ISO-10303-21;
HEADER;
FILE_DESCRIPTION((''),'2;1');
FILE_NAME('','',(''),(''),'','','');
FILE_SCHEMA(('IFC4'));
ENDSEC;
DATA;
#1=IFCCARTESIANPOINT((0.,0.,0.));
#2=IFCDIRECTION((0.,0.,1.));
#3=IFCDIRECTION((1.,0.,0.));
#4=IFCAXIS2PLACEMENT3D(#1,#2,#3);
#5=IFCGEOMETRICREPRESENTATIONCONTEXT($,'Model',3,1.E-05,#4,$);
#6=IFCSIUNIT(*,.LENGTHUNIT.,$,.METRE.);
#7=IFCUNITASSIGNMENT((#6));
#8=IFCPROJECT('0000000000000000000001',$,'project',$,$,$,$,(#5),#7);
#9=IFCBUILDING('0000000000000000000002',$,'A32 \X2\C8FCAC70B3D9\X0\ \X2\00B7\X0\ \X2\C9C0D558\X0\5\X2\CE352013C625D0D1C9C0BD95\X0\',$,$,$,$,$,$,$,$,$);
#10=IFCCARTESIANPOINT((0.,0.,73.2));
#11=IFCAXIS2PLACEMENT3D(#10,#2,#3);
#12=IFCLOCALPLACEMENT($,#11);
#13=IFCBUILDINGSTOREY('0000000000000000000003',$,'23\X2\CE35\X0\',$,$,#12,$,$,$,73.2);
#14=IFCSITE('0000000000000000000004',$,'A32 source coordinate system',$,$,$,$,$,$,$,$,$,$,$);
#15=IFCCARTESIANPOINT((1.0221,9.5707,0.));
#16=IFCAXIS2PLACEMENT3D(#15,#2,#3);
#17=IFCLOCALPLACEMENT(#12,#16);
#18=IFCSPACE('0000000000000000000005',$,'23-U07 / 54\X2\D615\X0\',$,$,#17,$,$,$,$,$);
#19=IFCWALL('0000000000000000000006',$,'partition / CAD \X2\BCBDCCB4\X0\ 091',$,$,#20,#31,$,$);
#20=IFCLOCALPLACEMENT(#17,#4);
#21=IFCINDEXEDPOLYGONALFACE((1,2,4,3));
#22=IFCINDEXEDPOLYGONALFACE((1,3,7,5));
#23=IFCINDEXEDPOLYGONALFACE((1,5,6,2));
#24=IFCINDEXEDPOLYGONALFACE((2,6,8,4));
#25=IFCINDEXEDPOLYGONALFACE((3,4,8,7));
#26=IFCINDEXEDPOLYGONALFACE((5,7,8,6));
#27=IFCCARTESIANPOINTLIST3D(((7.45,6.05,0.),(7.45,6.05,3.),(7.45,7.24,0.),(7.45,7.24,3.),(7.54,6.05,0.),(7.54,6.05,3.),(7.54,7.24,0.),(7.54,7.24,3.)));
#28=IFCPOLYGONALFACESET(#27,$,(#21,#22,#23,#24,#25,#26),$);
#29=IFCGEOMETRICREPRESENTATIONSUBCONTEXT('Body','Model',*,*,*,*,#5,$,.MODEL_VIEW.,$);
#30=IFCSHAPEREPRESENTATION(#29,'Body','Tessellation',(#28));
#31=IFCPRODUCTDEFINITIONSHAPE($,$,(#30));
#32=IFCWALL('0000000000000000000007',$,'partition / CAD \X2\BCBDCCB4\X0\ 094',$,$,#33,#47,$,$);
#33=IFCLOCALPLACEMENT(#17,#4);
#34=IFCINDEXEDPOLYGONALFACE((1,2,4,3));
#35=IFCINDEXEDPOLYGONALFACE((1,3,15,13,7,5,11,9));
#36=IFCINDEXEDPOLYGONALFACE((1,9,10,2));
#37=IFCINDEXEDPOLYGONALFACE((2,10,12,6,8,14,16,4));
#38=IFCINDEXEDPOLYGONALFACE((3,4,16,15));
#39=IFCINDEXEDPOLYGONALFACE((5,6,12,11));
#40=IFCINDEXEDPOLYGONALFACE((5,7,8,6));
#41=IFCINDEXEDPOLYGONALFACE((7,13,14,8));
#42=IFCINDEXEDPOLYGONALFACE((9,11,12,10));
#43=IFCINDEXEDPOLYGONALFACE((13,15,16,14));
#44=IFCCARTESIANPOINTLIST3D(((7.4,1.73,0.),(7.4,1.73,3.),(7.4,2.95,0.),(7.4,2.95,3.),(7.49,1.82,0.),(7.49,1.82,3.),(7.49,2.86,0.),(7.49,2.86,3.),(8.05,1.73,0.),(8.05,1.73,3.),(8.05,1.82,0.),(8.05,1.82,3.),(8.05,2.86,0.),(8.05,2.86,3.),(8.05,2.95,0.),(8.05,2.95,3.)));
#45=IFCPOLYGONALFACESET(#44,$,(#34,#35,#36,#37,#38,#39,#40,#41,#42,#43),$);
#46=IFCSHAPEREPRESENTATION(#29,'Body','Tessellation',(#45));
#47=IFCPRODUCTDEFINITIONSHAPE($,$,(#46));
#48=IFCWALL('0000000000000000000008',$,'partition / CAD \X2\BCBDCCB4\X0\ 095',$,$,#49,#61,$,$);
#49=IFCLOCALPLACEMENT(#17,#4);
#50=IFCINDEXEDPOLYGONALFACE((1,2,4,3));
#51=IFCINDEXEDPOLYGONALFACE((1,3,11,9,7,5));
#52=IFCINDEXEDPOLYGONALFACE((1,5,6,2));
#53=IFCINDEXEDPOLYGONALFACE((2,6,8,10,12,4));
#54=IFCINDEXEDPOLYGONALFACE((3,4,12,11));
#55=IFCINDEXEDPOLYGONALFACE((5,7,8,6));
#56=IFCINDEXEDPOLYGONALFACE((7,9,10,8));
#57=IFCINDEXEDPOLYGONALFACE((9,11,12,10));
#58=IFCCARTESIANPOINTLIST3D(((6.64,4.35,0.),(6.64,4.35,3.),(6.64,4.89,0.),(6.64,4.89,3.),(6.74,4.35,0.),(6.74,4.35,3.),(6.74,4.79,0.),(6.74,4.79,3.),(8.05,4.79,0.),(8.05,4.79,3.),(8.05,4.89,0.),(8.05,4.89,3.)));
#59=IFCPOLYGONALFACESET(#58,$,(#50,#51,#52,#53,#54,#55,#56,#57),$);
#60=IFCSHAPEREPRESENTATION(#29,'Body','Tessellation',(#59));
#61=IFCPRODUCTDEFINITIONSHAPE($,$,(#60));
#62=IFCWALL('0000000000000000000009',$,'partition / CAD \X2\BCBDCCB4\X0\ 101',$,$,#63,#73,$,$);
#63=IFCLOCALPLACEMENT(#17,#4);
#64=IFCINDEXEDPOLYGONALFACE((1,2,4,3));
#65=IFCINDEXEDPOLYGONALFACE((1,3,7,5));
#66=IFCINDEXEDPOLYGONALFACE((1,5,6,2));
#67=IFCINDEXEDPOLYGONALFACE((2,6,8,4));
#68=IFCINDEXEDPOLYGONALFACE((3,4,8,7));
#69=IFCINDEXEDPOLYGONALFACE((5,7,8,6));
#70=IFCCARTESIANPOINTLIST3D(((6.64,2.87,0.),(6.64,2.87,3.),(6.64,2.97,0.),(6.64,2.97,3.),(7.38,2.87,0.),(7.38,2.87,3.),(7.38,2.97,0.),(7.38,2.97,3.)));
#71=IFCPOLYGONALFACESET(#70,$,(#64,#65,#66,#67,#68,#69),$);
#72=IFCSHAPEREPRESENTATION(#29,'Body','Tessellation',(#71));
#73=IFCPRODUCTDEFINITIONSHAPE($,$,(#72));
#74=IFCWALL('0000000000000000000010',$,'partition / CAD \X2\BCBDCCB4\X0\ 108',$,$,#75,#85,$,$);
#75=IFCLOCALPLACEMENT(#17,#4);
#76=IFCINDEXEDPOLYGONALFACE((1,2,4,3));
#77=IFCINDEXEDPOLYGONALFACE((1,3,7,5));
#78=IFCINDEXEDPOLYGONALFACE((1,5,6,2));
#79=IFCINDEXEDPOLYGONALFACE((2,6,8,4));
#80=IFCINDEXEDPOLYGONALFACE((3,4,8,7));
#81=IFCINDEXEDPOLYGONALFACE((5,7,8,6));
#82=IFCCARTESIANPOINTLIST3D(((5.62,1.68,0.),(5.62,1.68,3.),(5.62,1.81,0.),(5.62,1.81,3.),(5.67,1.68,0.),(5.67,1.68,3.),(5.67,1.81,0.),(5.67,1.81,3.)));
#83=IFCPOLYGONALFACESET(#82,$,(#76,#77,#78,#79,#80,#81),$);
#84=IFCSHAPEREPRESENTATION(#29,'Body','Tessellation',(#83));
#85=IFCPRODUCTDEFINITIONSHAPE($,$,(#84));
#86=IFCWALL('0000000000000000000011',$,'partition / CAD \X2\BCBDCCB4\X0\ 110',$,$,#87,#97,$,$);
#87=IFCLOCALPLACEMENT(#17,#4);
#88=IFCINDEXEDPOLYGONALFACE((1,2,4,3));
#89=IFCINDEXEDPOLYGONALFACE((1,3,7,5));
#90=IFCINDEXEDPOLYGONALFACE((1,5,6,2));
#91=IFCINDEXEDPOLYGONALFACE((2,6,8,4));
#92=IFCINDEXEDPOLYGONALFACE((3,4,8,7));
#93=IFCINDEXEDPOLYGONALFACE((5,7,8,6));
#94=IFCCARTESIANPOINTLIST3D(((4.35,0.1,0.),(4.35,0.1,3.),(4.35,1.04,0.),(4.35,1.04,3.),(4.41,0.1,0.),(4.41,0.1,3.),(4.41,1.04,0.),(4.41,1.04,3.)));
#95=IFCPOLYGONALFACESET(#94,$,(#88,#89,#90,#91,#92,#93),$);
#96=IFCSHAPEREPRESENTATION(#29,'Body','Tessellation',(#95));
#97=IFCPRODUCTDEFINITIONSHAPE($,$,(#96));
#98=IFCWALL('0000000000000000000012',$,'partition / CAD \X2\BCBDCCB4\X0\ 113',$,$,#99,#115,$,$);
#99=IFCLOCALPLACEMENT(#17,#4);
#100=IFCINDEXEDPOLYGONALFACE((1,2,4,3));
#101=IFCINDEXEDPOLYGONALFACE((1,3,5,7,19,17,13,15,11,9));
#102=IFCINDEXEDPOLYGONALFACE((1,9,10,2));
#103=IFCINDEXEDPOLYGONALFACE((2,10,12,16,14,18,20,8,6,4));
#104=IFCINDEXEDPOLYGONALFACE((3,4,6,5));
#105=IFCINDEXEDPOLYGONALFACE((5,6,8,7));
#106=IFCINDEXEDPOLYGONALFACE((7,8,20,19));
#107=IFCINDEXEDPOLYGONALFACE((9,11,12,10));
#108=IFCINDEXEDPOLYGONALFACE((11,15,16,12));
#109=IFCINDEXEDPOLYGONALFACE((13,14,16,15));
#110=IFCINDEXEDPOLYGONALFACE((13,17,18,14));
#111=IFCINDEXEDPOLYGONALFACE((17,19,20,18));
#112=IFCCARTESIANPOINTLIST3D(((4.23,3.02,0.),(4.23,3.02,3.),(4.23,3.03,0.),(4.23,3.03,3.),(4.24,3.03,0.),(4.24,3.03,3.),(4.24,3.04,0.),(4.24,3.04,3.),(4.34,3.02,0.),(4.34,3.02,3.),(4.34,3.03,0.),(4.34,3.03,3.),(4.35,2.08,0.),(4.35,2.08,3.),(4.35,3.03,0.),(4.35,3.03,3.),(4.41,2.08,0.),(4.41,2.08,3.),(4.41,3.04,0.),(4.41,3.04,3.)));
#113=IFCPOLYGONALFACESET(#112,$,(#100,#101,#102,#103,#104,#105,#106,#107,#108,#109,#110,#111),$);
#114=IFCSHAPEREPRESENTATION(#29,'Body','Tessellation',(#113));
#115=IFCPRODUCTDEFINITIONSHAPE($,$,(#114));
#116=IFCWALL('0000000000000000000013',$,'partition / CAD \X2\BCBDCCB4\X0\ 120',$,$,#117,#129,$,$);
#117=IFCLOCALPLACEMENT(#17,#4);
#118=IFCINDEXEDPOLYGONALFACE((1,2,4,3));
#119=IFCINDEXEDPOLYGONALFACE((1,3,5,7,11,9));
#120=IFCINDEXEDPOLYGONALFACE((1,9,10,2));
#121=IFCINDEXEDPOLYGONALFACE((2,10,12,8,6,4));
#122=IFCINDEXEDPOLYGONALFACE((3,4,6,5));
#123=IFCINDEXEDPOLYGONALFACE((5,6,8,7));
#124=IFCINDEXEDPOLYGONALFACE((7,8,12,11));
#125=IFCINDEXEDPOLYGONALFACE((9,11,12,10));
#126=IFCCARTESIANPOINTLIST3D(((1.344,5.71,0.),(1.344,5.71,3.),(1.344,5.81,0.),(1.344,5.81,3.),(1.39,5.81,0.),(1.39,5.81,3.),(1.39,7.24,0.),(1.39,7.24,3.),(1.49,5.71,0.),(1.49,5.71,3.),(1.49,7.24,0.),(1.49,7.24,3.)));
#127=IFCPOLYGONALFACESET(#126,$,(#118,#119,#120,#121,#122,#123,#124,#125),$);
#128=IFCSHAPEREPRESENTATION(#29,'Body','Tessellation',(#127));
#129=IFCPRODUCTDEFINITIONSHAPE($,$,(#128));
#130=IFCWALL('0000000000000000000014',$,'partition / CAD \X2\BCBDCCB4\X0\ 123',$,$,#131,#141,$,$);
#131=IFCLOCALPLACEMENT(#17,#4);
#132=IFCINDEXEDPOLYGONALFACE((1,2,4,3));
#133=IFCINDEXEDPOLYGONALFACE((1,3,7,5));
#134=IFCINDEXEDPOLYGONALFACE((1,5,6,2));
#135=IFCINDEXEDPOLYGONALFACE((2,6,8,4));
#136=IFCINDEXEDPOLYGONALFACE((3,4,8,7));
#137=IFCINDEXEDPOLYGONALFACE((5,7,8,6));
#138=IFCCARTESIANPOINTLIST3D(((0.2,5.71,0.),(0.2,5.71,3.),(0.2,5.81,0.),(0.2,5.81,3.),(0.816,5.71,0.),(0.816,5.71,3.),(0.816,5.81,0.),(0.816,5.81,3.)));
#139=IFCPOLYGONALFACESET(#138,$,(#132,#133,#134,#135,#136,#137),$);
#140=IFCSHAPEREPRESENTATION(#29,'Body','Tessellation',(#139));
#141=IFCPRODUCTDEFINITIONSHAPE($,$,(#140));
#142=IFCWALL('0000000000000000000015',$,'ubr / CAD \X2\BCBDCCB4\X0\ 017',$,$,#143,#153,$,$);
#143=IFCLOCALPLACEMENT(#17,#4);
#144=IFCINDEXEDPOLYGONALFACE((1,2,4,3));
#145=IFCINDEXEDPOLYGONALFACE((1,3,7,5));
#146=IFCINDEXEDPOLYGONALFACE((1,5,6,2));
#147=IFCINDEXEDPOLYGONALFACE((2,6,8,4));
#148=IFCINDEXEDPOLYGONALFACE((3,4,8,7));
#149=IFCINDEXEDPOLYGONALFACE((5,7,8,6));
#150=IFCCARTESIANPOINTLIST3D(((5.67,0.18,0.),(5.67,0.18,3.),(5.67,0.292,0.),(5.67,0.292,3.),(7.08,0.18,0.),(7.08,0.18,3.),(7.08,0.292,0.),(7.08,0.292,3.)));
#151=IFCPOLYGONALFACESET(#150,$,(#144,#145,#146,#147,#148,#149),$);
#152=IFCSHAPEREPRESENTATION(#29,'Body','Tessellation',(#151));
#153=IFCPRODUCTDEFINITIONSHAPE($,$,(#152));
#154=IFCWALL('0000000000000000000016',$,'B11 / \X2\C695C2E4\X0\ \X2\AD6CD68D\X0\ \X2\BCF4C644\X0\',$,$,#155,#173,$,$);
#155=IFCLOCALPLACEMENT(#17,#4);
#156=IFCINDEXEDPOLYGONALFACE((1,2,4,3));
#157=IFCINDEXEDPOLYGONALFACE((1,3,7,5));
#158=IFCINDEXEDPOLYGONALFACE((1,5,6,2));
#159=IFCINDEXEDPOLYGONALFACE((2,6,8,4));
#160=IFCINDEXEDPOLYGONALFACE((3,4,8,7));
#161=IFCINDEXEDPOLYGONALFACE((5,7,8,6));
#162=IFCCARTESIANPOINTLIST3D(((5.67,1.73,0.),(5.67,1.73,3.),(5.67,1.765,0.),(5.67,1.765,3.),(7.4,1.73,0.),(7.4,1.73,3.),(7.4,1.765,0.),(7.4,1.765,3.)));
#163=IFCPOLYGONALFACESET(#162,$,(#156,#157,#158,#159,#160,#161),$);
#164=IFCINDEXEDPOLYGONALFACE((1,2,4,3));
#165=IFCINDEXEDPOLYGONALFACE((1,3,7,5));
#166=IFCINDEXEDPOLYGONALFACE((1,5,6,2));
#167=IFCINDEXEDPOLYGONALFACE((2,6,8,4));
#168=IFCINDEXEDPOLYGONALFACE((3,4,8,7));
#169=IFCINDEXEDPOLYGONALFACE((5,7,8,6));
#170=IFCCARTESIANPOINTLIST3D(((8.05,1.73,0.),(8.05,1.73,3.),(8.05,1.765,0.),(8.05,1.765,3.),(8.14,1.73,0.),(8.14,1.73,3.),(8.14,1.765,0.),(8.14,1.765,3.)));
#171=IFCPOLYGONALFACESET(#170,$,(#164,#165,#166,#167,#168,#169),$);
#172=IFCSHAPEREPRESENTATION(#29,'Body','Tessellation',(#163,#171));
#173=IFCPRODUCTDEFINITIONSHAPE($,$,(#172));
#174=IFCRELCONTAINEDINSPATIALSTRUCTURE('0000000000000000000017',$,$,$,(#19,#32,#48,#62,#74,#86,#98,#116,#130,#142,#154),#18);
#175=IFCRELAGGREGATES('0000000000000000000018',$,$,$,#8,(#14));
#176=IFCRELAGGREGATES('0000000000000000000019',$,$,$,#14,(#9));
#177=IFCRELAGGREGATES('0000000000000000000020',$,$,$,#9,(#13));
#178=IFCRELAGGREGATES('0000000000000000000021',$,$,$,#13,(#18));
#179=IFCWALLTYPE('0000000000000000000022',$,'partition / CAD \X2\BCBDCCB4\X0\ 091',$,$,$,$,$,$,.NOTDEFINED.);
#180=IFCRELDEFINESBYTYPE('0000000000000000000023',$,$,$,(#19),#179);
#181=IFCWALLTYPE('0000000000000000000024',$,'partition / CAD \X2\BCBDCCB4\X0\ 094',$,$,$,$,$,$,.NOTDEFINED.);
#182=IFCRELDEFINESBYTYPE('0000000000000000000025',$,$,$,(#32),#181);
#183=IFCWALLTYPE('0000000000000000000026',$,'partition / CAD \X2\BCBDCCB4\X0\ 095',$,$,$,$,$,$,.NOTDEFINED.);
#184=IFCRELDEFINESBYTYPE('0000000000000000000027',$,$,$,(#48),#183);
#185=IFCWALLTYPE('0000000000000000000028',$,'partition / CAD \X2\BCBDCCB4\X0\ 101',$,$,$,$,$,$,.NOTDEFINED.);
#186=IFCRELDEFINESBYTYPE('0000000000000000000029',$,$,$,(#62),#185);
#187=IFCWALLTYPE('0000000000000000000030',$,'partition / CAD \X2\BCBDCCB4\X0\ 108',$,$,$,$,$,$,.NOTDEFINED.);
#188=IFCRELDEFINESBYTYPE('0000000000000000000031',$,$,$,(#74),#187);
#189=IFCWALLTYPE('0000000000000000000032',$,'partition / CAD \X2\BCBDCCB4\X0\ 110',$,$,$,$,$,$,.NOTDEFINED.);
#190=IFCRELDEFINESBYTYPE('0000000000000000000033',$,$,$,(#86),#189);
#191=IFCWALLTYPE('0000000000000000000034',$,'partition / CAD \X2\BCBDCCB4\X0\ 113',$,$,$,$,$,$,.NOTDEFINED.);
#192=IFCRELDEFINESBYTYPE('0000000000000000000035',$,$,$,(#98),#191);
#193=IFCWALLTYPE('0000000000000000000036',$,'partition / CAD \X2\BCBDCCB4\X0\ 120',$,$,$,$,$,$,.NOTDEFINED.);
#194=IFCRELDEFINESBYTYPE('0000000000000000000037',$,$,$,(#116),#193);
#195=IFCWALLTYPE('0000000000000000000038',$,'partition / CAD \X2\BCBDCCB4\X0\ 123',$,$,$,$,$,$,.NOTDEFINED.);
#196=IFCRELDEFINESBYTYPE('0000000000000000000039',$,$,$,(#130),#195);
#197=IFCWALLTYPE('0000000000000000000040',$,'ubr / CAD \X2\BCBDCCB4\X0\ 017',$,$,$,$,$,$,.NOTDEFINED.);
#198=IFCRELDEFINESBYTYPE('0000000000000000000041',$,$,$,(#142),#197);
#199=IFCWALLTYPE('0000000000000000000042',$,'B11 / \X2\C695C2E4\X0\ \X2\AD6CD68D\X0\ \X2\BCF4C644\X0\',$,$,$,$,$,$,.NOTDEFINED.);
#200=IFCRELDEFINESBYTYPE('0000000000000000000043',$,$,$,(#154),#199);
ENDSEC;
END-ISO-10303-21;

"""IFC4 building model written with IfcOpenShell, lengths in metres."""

from ifc_helpers import new_model, si_unit, frame, origin, origin_with_axes, place, context, subcontext, project, spatial, polyline, outline, extrude, source, transform, mapped, type_object, type_shapes, element, save


model = new_model("IFC4")

# Units and contexts
model_context = context("Model", 3, precision=1e-05, world=origin_with_axes())
body_context = subcontext(model_context, "Body", "Model", "MODEL_VIEW")
ifc_project = project(units=[si_unit("LENGTHUNIT", "METRE")], contexts=[model_context])

# Site, building, storey, space
site = spatial("IfcSite", under=ifc_project, Name="A32 source coordinate system")
building = spatial("IfcBuilding", under=site, Name="A32 주거동 · 지하5층–옥탑지붕")
storey_placement = place(None, frame((0.0, 0.0, 73.2), z_axis=(0.0, 0.0, 1.0), x_axis=(1.0, 0.0, 0.0)))
storey = spatial("IfcBuildingStorey", under=building, at=storey_placement, Name="23층", Elevation=73.2)
space_1_placement = place(storey_placement, frame((1.0221, 9.5707, 0.0), z_axis=(0.0, 0.0, 1.0), x_axis=(1.0, 0.0, 0.0)))
space_1 = spatial("IfcSpace", under=storey, at=space_1_placement, Name="23-U07 / 54형")

# Walls
wall_type_1 = type_object("IfcWallType", Name="partition / CAD 벽체 091", PredefinedType="NOTDEFINED")
shared_shape_1 = source(origin(), body_context, "Body", "SweptSolid", [
    extrude(outline(polyline([(7.54, 6.05), (7.45, 6.05), (7.45, 7.24), (7.54, 7.24), (7.54, 6.05)])), origin(), (0.0, 0.0, 1.0), 3.0),
])
type_shapes(wall_type_1, [shared_shape_1])
wall_1_placement = place(space_1_placement, origin_with_axes())
element("IfcWall", 1, at=wall_1_placement, inside=space_1, type_object=wall_type_1, Name="partition / CAD 벽체 091", context=body_context, shape_type="MappedRepresentation", body=[
    mapped(shared_shape_1, transform((0.0, 0.0, 0.0), scale=1.0)),
])
wall_type_2 = type_object("IfcWallType", Name="partition / CAD 벽체 094", PredefinedType="NOTDEFINED")
shared_shape_2 = source(origin(), body_context, "Body", "SweptSolid", [
    extrude(outline(polyline([(8.05, 1.73), (7.4, 1.73), (7.4, 2.95), (8.05, 2.95), (8.05, 2.86), (7.49, 2.86), (7.49, 1.82), (8.05, 1.82), (8.05, 1.73)])), origin(), (0.0, 0.0, 1.0), 3.0),
])
type_shapes(wall_type_2, [shared_shape_2])
wall_2_placement = place(space_1_placement, origin_with_axes())
element("IfcWall", 2, at=wall_2_placement, inside=space_1, type_object=wall_type_2, Name="partition / CAD 벽체 094", context=body_context, shape_type="MappedRepresentation", body=[
    mapped(shared_shape_2, transform((0.0, 0.0, 0.0), scale=1.0)),
])
wall_type_3 = type_object("IfcWallType", Name="partition / CAD 벽체 095", PredefinedType="NOTDEFINED")
shared_shape_3 = source(origin(), body_context, "Body", "SweptSolid", [
    extrude(outline(polyline([(6.64, 4.89), (8.05, 4.89), (8.05, 4.79), (6.74, 4.79), (6.74, 4.35), (6.64, 4.35), (6.64, 4.89)])), origin(), (0.0, 0.0, 1.0), 3.0),
])
type_shapes(wall_type_3, [shared_shape_3])
wall_3_placement = place(space_1_placement, origin_with_axes())
element("IfcWall", 3, at=wall_3_placement, inside=space_1, type_object=wall_type_3, Name="partition / CAD 벽체 095", context=body_context, shape_type="MappedRepresentation", body=[
    mapped(shared_shape_3, transform((0.0, 0.0, 0.0), scale=1.0)),
])
wall_type_4 = type_object("IfcWallType", Name="partition / CAD 벽체 101", PredefinedType="NOTDEFINED")
shared_shape_4 = source(origin(), body_context, "Body", "SweptSolid", [
    extrude(outline(polyline([(7.38, 2.97), (7.38, 2.87), (6.64, 2.87), (6.64, 2.97), (7.38, 2.97)])), origin(), (0.0, 0.0, 1.0), 3.0),
])
type_shapes(wall_type_4, [shared_shape_4])
wall_4_placement = place(space_1_placement, origin_with_axes())
element("IfcWall", 4, at=wall_4_placement, inside=space_1, type_object=wall_type_4, Name="partition / CAD 벽체 101", context=body_context, shape_type="MappedRepresentation", body=[
    mapped(shared_shape_4, transform((0.0, 0.0, 0.0), scale=1.0)),
])
wall_type_5 = type_object("IfcWallType", Name="partition / CAD 벽체 108", PredefinedType="NOTDEFINED")
shared_shape_5 = source(origin(), body_context, "Body", "SweptSolid", [
    extrude(outline(polyline([(5.67, 1.68), (5.62, 1.68), (5.62, 1.81), (5.67, 1.81), (5.67, 1.68)])), origin(), (0.0, 0.0, 1.0), 3.0),
])
type_shapes(wall_type_5, [shared_shape_5])
wall_5_placement = place(space_1_placement, origin_with_axes())
element("IfcWall", 5, at=wall_5_placement, inside=space_1, type_object=wall_type_5, Name="partition / CAD 벽체 108", context=body_context, shape_type="MappedRepresentation", body=[
    mapped(shared_shape_5, transform((0.0, 0.0, 0.0), scale=1.0)),
])
wall_type_6 = type_object("IfcWallType", Name="partition / CAD 벽체 110", PredefinedType="NOTDEFINED")
shared_shape_6 = source(origin(), body_context, "Body", "SweptSolid", [
    extrude(outline(polyline([(4.35, 1.04), (4.41, 1.04), (4.41, 0.1), (4.35, 0.1), (4.35, 1.04)])), origin(), (0.0, 0.0, 1.0), 3.0),
])
type_shapes(wall_type_6, [shared_shape_6])
wall_6_placement = place(space_1_placement, origin_with_axes())
element("IfcWall", 6, at=wall_6_placement, inside=space_1, type_object=wall_type_6, Name="partition / CAD 벽체 110", context=body_context, shape_type="MappedRepresentation", body=[
    mapped(shared_shape_6, transform((0.0, 0.0, 0.0), scale=1.0)),
])
wall_type_7 = type_object("IfcWallType", Name="partition / CAD 벽체 113", PredefinedType="NOTDEFINED")
shared_shape_7 = source(origin(), body_context, "Body", "SweptSolid", [
    extrude(outline(polyline([(4.24, 3.04), (4.41, 3.04), (4.41, 2.08), (4.35, 2.08), (4.35, 3.03), (4.34, 3.03), (4.34, 3.02), (4.23, 3.02), (4.23, 3.03), (4.24, 3.03), (4.24, 3.04)])), origin(), (0.0, 0.0, 1.0), 3.0),
])
type_shapes(wall_type_7, [shared_shape_7])
wall_7_placement = place(space_1_placement, origin_with_axes())
element("IfcWall", 7, at=wall_7_placement, inside=space_1, type_object=wall_type_7, Name="partition / CAD 벽체 113", context=body_context, shape_type="MappedRepresentation", body=[
    mapped(shared_shape_7, transform((0.0, 0.0, 0.0), scale=1.0)),
])
wall_type_8 = type_object("IfcWallType", Name="partition / CAD 벽체 120", PredefinedType="NOTDEFINED")
shared_shape_8 = source(origin(), body_context, "Body", "SweptSolid", [
    extrude(outline(polyline([(1.39, 7.24), (1.49, 7.24), (1.49, 5.71), (1.344, 5.71), (1.344, 5.81), (1.39, 5.81), (1.39, 7.24)])), origin(), (0.0, 0.0, 1.0), 3.0),
])
type_shapes(wall_type_8, [shared_shape_8])
wall_8_placement = place(space_1_placement, origin_with_axes())
element("IfcWall", 8, at=wall_8_placement, inside=space_1, type_object=wall_type_8, Name="partition / CAD 벽체 120", context=body_context, shape_type="MappedRepresentation", body=[
    mapped(shared_shape_8, transform((0.0, 0.0, 0.0), scale=1.0)),
])
wall_type_9 = type_object("IfcWallType", Name="partition / CAD 벽체 123", PredefinedType="NOTDEFINED")
shared_shape_9 = source(origin(), body_context, "Body", "SweptSolid", [
    extrude(outline(polyline([(0.816, 5.81), (0.816, 5.71), (0.2, 5.71), (0.2, 5.81), (0.816, 5.81)])), origin(), (0.0, 0.0, 1.0), 3.0),
])
type_shapes(wall_type_9, [shared_shape_9])
wall_9_placement = place(space_1_placement, origin_with_axes())
element("IfcWall", 9, at=wall_9_placement, inside=space_1, type_object=wall_type_9, Name="partition / CAD 벽체 123", context=body_context, shape_type="MappedRepresentation", body=[
    mapped(shared_shape_9, transform((0.0, 0.0, 0.0), scale=1.0)),
])
wall_type_10 = type_object("IfcWallType", Name="ubr / CAD 벽체 017", PredefinedType="NOTDEFINED")
shared_shape_10 = source(origin(), body_context, "Body", "SweptSolid", [
    extrude(outline(polyline([(7.08, 0.292), (7.08, 0.18), (5.67, 0.18), (5.67, 0.292), (7.08, 0.292)])), origin(), (0.0, 0.0, 1.0), 3.0),
])
type_shapes(wall_type_10, [shared_shape_10])
wall_10_placement = place(space_1_placement, origin_with_axes())
element("IfcWall", 10, at=wall_10_placement, inside=space_1, type_object=wall_type_10, Name="ubr / CAD 벽체 017", context=body_context, shape_type="MappedRepresentation", body=[
    mapped(shared_shape_10, transform((0.0, 0.0, 0.0), scale=1.0)),
])
wall_type_11 = type_object("IfcWallType", Name="B11 / 욕실 구획 보완", PredefinedType="NOTDEFINED")
shared_shape_11 = source(origin(), body_context, "Body", "SweptSolid", [
    extrude(outline(polyline([(7.4, 1.765), (7.4, 1.73), (5.67, 1.73), (5.67, 1.765), (7.4, 1.765)])), origin(), (0.0, 0.0, 1.0), 3.0),
    extrude(outline(polyline([(8.05, 1.73), (8.05, 1.765), (8.14, 1.765), (8.14, 1.73), (8.05, 1.73)])), origin(), (0.0, 0.0, 1.0), 3.0),
])
type_shapes(wall_type_11, [shared_shape_11])
wall_11_placement = place(space_1_placement, origin_with_axes())
element("IfcWall", 11, at=wall_11_placement, inside=space_1, type_object=wall_type_11, Name="B11 / 욕실 구획 보완", context=body_context, shape_type="MappedRepresentation", body=[
    mapped(shared_shape_11, transform((0.0, 0.0, 0.0), scale=1.0)),
])

save(model, "model.ifc")
